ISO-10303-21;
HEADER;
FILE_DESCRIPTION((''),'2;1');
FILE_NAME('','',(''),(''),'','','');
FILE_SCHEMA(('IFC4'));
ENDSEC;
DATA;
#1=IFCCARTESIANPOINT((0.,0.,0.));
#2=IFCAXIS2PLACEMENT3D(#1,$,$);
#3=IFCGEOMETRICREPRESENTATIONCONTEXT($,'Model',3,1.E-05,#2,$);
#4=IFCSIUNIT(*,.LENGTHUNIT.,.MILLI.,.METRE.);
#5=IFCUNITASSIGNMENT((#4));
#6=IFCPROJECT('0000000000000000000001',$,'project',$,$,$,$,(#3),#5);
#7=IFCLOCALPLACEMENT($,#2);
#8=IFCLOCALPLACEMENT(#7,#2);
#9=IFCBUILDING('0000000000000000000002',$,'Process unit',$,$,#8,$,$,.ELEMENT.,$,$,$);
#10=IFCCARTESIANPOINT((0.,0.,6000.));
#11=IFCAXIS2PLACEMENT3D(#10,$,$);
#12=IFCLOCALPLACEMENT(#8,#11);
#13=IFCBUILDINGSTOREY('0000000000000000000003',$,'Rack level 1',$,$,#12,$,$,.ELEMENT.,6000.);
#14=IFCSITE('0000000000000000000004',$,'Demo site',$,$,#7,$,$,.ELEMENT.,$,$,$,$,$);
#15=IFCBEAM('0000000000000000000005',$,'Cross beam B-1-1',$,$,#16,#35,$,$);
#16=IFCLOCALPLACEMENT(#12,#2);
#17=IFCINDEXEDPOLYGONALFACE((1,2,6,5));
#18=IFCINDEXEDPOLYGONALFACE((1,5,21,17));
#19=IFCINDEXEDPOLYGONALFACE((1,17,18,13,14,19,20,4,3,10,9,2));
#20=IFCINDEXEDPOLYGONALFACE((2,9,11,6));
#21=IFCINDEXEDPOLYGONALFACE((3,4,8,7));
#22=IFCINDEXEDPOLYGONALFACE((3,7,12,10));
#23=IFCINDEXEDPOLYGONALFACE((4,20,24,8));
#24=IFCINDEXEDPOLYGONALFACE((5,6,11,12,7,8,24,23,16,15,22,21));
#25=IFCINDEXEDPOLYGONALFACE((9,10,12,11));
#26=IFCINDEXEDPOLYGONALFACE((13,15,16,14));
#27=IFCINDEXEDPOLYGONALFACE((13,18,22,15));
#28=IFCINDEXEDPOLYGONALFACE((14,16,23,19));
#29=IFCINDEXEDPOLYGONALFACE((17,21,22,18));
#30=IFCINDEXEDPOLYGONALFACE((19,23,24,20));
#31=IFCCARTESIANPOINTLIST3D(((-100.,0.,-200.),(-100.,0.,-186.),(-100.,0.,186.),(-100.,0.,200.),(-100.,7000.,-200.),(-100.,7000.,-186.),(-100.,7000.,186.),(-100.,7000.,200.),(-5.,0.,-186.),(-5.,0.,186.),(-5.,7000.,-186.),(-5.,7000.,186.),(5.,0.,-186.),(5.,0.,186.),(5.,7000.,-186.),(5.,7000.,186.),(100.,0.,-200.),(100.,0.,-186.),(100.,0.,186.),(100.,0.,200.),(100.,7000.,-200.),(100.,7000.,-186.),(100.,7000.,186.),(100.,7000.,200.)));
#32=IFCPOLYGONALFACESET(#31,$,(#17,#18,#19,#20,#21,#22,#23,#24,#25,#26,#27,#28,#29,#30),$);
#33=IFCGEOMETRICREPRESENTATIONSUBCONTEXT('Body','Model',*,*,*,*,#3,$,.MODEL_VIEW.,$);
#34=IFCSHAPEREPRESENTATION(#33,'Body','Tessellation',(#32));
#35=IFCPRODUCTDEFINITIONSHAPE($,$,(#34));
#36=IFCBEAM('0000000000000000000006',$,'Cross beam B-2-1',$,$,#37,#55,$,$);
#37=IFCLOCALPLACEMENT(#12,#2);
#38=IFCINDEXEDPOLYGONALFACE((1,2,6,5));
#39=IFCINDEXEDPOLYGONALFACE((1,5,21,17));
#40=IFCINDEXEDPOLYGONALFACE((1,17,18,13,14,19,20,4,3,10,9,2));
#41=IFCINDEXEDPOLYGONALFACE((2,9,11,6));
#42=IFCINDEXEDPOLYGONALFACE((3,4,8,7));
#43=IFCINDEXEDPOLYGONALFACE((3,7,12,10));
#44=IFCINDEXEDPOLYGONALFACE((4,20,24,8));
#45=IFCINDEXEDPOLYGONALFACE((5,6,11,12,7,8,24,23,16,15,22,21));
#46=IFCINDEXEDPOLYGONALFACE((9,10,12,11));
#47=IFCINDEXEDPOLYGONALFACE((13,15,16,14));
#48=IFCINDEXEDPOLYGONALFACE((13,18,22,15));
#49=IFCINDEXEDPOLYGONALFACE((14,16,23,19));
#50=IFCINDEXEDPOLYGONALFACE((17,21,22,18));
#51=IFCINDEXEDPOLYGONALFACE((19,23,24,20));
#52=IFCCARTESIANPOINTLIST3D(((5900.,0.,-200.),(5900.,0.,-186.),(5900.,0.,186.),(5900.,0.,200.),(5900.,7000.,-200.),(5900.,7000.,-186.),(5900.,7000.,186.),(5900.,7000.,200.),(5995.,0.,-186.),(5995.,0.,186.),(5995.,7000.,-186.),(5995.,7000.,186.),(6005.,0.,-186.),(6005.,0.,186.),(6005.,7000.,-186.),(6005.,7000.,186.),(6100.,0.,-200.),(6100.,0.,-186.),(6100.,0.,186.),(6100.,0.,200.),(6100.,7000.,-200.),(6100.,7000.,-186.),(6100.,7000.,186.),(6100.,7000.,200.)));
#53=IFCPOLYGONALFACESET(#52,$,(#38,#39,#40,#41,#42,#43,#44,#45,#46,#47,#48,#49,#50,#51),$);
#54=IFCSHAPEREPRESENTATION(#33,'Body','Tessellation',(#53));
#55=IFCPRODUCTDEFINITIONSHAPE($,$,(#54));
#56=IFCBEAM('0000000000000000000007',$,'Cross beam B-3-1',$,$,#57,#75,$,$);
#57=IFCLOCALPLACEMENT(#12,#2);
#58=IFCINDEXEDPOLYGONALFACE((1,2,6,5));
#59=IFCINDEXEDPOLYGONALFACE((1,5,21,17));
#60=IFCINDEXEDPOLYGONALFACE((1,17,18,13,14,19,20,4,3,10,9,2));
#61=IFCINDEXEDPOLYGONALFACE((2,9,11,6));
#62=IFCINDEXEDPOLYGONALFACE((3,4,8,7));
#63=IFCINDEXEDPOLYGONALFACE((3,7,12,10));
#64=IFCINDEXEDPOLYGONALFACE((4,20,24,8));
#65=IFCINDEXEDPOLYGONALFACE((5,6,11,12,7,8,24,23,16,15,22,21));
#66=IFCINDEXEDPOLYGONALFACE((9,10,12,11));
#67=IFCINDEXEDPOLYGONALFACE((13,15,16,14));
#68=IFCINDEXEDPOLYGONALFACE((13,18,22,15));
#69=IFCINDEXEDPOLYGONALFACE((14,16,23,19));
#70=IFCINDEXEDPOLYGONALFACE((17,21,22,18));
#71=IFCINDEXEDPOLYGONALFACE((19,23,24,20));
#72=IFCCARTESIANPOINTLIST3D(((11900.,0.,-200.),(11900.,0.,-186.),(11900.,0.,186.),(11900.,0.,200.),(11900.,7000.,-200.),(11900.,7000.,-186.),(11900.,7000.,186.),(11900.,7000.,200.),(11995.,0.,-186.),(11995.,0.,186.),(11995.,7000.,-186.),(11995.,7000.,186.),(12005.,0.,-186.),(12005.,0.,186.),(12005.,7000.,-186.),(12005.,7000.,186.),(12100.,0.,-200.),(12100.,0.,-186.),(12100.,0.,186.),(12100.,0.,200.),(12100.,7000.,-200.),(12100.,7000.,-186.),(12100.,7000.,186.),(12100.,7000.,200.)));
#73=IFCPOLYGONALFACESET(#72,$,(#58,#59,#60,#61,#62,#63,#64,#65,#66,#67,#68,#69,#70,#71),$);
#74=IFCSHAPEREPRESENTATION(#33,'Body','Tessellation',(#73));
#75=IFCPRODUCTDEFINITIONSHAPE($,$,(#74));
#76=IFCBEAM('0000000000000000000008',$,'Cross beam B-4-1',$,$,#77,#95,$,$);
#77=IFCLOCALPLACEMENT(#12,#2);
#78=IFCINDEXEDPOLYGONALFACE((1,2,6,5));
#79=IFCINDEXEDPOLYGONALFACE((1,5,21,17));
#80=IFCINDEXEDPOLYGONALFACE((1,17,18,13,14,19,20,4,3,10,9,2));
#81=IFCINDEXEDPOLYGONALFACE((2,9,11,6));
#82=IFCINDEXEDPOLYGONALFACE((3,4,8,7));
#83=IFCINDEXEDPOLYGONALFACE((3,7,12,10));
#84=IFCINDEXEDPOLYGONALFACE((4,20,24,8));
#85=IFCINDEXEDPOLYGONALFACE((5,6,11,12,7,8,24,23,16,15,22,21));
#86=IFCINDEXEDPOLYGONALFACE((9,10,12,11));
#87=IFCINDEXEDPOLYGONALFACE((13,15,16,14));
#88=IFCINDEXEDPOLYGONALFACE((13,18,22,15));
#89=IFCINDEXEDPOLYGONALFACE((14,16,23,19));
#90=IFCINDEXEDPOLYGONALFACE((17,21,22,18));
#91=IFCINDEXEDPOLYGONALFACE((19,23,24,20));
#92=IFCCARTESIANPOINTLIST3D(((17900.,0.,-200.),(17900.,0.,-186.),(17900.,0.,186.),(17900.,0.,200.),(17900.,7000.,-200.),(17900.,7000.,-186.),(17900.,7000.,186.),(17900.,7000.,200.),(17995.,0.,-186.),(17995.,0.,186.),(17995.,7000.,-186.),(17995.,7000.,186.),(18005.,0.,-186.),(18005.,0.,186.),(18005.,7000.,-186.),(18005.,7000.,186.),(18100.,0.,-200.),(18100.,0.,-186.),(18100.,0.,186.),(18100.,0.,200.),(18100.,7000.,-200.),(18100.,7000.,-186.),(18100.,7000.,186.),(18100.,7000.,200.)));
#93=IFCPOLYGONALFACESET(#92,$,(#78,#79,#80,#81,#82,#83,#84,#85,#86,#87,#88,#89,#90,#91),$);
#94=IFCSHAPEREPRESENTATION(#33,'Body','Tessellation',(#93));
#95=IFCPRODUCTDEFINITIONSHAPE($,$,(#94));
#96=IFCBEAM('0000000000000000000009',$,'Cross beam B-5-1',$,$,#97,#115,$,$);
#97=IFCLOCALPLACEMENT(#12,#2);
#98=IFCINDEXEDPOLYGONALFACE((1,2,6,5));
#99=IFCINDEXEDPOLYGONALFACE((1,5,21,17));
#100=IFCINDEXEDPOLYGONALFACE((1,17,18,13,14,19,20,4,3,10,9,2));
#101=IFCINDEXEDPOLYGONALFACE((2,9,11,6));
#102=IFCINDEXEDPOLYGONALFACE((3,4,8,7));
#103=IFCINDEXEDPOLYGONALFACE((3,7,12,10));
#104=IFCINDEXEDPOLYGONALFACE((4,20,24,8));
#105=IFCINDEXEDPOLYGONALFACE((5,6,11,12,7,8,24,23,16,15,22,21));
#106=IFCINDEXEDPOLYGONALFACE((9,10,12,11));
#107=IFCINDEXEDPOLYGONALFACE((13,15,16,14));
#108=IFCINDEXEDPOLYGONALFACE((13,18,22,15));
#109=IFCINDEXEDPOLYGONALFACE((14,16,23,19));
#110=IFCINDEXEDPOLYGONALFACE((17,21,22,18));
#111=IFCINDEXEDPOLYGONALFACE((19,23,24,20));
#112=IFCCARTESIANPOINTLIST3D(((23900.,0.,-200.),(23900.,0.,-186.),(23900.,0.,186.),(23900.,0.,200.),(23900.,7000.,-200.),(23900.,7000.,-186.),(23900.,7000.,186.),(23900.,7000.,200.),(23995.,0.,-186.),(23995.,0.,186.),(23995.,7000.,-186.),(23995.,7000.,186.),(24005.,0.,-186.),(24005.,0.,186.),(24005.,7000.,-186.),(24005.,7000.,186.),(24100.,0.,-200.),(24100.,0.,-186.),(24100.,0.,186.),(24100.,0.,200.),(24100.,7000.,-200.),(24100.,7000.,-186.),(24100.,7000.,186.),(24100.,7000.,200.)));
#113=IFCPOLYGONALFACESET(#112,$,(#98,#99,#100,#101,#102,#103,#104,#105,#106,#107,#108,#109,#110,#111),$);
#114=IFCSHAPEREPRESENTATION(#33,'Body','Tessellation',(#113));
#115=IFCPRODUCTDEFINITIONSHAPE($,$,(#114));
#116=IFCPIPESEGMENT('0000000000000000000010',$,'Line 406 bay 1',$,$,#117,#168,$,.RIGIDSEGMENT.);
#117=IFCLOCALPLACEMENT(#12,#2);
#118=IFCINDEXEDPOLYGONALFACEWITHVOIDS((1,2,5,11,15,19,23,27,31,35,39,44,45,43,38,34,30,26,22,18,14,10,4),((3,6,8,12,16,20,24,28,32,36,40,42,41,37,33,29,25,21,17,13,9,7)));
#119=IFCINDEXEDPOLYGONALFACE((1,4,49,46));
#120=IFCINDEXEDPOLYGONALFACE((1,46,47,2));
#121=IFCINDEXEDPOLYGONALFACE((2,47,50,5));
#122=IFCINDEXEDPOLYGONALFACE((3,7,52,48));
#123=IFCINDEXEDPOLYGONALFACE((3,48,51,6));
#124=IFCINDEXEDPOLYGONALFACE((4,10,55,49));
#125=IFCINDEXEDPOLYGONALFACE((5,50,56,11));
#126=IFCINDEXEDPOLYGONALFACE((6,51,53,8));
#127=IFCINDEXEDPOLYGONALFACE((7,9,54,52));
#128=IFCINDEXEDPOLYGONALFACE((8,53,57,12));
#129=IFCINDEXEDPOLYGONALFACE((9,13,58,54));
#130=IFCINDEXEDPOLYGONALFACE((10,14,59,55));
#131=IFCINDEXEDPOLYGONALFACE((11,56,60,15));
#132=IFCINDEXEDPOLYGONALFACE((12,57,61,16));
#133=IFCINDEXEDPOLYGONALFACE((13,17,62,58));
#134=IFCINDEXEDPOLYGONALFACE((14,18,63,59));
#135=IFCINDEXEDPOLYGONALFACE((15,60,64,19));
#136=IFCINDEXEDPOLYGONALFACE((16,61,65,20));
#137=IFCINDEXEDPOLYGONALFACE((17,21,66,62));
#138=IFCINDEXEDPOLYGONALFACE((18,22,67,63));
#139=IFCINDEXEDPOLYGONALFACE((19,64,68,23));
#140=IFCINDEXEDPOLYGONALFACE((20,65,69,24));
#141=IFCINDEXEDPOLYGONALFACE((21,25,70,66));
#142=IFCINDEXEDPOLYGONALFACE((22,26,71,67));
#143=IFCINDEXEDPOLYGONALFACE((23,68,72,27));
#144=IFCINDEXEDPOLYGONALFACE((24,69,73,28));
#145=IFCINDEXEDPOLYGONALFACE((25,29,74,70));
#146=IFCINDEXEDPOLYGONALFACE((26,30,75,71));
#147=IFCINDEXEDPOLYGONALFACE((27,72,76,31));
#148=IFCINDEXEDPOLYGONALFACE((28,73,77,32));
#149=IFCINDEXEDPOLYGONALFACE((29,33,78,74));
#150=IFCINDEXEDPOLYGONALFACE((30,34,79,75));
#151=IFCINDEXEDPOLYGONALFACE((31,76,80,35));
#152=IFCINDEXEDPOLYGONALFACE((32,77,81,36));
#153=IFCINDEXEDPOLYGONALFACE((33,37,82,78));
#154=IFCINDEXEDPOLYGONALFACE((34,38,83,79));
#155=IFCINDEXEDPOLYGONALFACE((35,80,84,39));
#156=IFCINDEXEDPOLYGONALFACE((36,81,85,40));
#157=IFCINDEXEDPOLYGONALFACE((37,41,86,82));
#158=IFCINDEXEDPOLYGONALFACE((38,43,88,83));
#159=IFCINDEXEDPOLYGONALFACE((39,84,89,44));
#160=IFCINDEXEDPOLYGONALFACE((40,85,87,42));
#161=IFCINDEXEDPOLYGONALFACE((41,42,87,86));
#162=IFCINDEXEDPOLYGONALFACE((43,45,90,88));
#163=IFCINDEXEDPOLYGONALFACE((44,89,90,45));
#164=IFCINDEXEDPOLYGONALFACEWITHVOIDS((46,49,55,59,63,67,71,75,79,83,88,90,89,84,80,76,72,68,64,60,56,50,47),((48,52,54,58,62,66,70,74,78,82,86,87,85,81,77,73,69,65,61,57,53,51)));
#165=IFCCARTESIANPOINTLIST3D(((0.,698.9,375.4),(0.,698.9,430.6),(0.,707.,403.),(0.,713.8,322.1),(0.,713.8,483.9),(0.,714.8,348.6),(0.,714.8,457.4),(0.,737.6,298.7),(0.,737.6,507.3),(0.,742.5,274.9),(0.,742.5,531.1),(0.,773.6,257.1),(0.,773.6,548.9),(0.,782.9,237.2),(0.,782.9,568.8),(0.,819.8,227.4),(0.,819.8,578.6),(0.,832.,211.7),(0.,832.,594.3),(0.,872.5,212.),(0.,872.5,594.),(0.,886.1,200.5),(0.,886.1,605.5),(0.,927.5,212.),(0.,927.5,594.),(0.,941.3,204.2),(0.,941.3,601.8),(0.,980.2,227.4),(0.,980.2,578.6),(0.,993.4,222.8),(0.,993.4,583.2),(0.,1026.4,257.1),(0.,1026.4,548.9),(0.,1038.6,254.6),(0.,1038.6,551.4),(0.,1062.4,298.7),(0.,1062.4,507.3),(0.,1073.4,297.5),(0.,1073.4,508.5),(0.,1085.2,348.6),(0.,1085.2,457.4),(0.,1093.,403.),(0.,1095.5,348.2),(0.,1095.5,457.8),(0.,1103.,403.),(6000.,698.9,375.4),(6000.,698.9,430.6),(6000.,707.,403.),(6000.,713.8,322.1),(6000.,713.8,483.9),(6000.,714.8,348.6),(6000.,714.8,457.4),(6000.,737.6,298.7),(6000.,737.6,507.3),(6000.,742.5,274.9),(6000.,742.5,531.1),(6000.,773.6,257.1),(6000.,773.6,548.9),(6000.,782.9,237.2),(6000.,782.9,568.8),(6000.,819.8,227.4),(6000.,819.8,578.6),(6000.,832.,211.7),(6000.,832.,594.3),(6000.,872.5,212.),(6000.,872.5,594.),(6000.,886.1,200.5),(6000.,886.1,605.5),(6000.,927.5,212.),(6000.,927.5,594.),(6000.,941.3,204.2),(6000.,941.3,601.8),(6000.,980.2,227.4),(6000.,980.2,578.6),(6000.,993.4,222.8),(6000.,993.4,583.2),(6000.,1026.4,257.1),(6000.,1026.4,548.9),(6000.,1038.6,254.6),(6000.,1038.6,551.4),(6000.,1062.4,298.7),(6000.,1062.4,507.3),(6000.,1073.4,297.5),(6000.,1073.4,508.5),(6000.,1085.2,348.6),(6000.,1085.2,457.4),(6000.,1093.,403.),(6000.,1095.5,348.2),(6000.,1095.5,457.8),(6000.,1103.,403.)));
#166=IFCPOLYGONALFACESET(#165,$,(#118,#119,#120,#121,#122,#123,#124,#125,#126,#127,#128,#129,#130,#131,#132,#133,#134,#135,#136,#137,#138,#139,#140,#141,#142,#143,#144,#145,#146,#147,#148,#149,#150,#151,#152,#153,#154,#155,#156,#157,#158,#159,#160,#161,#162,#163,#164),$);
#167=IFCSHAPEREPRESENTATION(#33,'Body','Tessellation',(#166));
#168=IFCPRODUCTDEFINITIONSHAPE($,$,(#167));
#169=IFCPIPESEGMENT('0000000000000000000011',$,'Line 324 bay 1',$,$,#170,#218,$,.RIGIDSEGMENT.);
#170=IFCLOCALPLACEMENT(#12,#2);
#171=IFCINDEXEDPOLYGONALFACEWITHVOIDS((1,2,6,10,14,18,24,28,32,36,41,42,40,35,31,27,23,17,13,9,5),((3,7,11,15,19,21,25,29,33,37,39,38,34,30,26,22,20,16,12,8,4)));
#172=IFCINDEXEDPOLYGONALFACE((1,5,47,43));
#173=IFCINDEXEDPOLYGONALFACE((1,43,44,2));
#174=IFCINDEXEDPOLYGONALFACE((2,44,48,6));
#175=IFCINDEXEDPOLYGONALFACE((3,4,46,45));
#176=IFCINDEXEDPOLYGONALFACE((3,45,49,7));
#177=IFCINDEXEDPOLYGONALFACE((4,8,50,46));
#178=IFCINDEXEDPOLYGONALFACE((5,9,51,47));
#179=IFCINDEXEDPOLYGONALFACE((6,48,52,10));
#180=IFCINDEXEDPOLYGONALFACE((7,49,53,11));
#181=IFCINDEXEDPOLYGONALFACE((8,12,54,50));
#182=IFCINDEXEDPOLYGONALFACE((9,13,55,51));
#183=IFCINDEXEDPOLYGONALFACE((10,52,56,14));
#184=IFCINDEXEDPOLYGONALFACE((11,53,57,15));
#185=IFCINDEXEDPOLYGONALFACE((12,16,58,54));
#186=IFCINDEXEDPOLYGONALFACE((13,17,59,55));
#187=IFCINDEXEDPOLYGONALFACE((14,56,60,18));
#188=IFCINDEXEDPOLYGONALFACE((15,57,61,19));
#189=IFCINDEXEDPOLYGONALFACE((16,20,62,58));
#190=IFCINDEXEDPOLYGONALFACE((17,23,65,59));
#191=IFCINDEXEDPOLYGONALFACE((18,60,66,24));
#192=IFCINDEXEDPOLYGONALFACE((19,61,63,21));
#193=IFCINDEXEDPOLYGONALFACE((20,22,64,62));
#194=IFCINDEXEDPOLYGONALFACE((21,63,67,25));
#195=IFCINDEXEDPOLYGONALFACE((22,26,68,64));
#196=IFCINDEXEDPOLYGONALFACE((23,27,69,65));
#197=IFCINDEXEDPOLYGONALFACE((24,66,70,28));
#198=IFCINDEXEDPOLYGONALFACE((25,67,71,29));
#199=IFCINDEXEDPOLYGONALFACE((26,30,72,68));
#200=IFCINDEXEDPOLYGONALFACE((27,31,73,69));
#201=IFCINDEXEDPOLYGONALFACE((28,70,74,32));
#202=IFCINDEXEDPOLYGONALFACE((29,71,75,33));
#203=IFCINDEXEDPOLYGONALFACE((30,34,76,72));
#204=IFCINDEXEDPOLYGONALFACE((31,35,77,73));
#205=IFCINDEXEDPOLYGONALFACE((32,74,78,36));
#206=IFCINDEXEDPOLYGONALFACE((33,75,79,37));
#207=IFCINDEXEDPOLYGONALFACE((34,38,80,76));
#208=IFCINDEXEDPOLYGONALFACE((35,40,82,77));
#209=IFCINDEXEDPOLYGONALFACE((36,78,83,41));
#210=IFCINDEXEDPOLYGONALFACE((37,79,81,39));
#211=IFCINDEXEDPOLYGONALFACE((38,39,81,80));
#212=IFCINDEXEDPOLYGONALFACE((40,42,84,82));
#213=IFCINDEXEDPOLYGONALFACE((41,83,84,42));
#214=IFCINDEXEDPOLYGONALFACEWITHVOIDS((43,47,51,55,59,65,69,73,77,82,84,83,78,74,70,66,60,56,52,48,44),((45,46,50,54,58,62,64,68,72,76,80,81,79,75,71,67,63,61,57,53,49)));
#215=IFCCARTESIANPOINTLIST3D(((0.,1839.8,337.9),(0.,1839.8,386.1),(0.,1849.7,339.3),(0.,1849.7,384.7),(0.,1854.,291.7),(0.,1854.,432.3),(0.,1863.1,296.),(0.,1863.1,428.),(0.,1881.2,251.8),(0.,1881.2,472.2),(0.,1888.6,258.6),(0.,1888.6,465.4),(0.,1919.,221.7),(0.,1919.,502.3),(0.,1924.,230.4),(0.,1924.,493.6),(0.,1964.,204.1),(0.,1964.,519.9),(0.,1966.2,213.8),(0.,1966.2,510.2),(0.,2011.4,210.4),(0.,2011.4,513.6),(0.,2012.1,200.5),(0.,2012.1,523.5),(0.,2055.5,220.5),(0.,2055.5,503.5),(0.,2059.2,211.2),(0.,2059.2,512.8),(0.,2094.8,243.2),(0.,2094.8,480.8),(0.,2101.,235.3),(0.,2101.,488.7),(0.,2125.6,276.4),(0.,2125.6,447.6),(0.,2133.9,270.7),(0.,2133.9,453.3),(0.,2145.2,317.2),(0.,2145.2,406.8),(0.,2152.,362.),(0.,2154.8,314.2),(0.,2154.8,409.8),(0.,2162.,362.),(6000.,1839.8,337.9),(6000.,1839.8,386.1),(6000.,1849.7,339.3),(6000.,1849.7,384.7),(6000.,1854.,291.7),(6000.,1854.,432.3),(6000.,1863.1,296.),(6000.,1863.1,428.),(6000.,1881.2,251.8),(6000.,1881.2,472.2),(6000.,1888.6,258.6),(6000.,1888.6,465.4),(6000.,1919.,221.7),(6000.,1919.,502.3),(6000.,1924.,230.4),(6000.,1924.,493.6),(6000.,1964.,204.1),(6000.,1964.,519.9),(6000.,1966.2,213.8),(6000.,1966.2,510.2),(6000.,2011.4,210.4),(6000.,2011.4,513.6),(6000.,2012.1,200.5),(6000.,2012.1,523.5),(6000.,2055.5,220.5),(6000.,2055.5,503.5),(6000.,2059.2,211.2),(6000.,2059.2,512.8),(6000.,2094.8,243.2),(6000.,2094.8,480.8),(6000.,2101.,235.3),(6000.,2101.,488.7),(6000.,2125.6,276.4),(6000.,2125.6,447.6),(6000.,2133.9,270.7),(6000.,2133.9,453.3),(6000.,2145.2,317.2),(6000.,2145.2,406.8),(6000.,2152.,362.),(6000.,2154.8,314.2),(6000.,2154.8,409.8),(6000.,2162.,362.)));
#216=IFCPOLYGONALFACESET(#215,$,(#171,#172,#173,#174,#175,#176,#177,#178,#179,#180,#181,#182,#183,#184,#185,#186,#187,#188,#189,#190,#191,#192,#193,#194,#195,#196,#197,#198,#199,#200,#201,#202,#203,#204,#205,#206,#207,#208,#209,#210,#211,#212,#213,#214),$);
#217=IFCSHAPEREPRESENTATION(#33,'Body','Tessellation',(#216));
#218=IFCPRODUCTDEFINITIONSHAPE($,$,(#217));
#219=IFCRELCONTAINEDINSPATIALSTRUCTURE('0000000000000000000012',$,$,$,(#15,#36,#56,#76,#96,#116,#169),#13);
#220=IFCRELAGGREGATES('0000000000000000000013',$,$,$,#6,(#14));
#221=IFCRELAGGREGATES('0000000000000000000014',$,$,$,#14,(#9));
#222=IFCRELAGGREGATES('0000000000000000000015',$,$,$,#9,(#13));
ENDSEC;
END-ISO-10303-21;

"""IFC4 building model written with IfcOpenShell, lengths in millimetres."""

from ifc_helpers import new_model, si_unit, frame, origin, place, context, subcontext, project, spatial, hollow_circle, i_section, extrude, element, save


model = new_model("IFC4")

# Units and contexts
model_context = context("Model", 3, precision=1e-05, world=origin())
body_context = subcontext(model_context, "Body", "Model", "MODEL_VIEW")
ifc_project = project(units=[si_unit("LENGTHUNIT", "METRE", prefix="MILLI")], contexts=[model_context])

# Site, building, storey
site_placement = place(None, origin())
site = spatial("IfcSite", under=ifc_project, at=site_placement, Name="Demo site", CompositionType="ELEMENT")
building_placement = place(site_placement, origin())
building = spatial("IfcBuilding", under=site, at=building_placement, Name="Process unit", CompositionType="ELEMENT")
storey_placement = place(building_placement, frame((0.0, 0.0, 6000.0)))
storey = spatial("IfcBuildingStorey", under=building, at=storey_placement, Name="Rack level 1", CompositionType="ELEMENT", Elevation=6000.0)

# Beams
for number, where, name in (
    (1, (0.0, 0.0, 0.0), "Cross beam B-1-1"),
    (2, (6000.0, 0.0, 0.0), "Cross beam B-2-1"),
    (3, (12000.0, 0.0, 0.0), "Cross beam B-3-1"),
    (4, (18000.0, 0.0, 0.0), "Cross beam B-4-1"),
    (5, (24000.0, 0.0, 0.0), "Cross beam B-5-1"),
):
    element("IfcBeam", number, at=place(storey_placement, frame(where)), inside=storey, Name=name, context=body_context, shape_type="SweptSolid", body=[
        extrude(i_section(OverallWidth=200.0, OverallDepth=400.0, WebThickness=10.0, FlangeThickness=14.0), frame((0.0, 0.0, 0.0), z_axis=(0.0, 1.0, 0.0), x_axis=(1.0, 0.0, 0.0)), (0.0, 0.0, 1.0), 7000.0),
    ])

# Pipe segments
pipe_segment_1_placement = place(storey_placement, frame((0.0, 900.0, 403.0)))
element("IfcPipeSegment", 6, at=pipe_segment_1_placement, inside=storey, Name="Line 406 bay 1", PredefinedType="RIGIDSEGMENT", context=body_context, shape_type="SweptSolid", body=[
    extrude(hollow_circle(Radius=203.0, WallThickness=10.0), frame((0.0, 0.0, 0.0), z_axis=(1.0, 0.0, 0.0), x_axis=(0.0, 1.0, 0.0)), (0.0, 0.0, 1.0), 6000.0),
])
pipe_segment_2_placement = place(storey_placement, frame((0.0, 2000.0, 362.0)))
element("IfcPipeSegment", 7, at=pipe_segment_2_placement, inside=storey, Name="Line 324 bay 1", PredefinedType="RIGIDSEGMENT", context=body_context, shape_type="SweptSolid", body=[
    extrude(hollow_circle(Radius=162.0, WallThickness=10.0), frame((0.0, 0.0, 0.0), z_axis=(1.0, 0.0, 0.0), x_axis=(0.0, 1.0, 0.0)), (0.0, 0.0, 1.0), 6000.0),
])

save(model, "model.ifc")
